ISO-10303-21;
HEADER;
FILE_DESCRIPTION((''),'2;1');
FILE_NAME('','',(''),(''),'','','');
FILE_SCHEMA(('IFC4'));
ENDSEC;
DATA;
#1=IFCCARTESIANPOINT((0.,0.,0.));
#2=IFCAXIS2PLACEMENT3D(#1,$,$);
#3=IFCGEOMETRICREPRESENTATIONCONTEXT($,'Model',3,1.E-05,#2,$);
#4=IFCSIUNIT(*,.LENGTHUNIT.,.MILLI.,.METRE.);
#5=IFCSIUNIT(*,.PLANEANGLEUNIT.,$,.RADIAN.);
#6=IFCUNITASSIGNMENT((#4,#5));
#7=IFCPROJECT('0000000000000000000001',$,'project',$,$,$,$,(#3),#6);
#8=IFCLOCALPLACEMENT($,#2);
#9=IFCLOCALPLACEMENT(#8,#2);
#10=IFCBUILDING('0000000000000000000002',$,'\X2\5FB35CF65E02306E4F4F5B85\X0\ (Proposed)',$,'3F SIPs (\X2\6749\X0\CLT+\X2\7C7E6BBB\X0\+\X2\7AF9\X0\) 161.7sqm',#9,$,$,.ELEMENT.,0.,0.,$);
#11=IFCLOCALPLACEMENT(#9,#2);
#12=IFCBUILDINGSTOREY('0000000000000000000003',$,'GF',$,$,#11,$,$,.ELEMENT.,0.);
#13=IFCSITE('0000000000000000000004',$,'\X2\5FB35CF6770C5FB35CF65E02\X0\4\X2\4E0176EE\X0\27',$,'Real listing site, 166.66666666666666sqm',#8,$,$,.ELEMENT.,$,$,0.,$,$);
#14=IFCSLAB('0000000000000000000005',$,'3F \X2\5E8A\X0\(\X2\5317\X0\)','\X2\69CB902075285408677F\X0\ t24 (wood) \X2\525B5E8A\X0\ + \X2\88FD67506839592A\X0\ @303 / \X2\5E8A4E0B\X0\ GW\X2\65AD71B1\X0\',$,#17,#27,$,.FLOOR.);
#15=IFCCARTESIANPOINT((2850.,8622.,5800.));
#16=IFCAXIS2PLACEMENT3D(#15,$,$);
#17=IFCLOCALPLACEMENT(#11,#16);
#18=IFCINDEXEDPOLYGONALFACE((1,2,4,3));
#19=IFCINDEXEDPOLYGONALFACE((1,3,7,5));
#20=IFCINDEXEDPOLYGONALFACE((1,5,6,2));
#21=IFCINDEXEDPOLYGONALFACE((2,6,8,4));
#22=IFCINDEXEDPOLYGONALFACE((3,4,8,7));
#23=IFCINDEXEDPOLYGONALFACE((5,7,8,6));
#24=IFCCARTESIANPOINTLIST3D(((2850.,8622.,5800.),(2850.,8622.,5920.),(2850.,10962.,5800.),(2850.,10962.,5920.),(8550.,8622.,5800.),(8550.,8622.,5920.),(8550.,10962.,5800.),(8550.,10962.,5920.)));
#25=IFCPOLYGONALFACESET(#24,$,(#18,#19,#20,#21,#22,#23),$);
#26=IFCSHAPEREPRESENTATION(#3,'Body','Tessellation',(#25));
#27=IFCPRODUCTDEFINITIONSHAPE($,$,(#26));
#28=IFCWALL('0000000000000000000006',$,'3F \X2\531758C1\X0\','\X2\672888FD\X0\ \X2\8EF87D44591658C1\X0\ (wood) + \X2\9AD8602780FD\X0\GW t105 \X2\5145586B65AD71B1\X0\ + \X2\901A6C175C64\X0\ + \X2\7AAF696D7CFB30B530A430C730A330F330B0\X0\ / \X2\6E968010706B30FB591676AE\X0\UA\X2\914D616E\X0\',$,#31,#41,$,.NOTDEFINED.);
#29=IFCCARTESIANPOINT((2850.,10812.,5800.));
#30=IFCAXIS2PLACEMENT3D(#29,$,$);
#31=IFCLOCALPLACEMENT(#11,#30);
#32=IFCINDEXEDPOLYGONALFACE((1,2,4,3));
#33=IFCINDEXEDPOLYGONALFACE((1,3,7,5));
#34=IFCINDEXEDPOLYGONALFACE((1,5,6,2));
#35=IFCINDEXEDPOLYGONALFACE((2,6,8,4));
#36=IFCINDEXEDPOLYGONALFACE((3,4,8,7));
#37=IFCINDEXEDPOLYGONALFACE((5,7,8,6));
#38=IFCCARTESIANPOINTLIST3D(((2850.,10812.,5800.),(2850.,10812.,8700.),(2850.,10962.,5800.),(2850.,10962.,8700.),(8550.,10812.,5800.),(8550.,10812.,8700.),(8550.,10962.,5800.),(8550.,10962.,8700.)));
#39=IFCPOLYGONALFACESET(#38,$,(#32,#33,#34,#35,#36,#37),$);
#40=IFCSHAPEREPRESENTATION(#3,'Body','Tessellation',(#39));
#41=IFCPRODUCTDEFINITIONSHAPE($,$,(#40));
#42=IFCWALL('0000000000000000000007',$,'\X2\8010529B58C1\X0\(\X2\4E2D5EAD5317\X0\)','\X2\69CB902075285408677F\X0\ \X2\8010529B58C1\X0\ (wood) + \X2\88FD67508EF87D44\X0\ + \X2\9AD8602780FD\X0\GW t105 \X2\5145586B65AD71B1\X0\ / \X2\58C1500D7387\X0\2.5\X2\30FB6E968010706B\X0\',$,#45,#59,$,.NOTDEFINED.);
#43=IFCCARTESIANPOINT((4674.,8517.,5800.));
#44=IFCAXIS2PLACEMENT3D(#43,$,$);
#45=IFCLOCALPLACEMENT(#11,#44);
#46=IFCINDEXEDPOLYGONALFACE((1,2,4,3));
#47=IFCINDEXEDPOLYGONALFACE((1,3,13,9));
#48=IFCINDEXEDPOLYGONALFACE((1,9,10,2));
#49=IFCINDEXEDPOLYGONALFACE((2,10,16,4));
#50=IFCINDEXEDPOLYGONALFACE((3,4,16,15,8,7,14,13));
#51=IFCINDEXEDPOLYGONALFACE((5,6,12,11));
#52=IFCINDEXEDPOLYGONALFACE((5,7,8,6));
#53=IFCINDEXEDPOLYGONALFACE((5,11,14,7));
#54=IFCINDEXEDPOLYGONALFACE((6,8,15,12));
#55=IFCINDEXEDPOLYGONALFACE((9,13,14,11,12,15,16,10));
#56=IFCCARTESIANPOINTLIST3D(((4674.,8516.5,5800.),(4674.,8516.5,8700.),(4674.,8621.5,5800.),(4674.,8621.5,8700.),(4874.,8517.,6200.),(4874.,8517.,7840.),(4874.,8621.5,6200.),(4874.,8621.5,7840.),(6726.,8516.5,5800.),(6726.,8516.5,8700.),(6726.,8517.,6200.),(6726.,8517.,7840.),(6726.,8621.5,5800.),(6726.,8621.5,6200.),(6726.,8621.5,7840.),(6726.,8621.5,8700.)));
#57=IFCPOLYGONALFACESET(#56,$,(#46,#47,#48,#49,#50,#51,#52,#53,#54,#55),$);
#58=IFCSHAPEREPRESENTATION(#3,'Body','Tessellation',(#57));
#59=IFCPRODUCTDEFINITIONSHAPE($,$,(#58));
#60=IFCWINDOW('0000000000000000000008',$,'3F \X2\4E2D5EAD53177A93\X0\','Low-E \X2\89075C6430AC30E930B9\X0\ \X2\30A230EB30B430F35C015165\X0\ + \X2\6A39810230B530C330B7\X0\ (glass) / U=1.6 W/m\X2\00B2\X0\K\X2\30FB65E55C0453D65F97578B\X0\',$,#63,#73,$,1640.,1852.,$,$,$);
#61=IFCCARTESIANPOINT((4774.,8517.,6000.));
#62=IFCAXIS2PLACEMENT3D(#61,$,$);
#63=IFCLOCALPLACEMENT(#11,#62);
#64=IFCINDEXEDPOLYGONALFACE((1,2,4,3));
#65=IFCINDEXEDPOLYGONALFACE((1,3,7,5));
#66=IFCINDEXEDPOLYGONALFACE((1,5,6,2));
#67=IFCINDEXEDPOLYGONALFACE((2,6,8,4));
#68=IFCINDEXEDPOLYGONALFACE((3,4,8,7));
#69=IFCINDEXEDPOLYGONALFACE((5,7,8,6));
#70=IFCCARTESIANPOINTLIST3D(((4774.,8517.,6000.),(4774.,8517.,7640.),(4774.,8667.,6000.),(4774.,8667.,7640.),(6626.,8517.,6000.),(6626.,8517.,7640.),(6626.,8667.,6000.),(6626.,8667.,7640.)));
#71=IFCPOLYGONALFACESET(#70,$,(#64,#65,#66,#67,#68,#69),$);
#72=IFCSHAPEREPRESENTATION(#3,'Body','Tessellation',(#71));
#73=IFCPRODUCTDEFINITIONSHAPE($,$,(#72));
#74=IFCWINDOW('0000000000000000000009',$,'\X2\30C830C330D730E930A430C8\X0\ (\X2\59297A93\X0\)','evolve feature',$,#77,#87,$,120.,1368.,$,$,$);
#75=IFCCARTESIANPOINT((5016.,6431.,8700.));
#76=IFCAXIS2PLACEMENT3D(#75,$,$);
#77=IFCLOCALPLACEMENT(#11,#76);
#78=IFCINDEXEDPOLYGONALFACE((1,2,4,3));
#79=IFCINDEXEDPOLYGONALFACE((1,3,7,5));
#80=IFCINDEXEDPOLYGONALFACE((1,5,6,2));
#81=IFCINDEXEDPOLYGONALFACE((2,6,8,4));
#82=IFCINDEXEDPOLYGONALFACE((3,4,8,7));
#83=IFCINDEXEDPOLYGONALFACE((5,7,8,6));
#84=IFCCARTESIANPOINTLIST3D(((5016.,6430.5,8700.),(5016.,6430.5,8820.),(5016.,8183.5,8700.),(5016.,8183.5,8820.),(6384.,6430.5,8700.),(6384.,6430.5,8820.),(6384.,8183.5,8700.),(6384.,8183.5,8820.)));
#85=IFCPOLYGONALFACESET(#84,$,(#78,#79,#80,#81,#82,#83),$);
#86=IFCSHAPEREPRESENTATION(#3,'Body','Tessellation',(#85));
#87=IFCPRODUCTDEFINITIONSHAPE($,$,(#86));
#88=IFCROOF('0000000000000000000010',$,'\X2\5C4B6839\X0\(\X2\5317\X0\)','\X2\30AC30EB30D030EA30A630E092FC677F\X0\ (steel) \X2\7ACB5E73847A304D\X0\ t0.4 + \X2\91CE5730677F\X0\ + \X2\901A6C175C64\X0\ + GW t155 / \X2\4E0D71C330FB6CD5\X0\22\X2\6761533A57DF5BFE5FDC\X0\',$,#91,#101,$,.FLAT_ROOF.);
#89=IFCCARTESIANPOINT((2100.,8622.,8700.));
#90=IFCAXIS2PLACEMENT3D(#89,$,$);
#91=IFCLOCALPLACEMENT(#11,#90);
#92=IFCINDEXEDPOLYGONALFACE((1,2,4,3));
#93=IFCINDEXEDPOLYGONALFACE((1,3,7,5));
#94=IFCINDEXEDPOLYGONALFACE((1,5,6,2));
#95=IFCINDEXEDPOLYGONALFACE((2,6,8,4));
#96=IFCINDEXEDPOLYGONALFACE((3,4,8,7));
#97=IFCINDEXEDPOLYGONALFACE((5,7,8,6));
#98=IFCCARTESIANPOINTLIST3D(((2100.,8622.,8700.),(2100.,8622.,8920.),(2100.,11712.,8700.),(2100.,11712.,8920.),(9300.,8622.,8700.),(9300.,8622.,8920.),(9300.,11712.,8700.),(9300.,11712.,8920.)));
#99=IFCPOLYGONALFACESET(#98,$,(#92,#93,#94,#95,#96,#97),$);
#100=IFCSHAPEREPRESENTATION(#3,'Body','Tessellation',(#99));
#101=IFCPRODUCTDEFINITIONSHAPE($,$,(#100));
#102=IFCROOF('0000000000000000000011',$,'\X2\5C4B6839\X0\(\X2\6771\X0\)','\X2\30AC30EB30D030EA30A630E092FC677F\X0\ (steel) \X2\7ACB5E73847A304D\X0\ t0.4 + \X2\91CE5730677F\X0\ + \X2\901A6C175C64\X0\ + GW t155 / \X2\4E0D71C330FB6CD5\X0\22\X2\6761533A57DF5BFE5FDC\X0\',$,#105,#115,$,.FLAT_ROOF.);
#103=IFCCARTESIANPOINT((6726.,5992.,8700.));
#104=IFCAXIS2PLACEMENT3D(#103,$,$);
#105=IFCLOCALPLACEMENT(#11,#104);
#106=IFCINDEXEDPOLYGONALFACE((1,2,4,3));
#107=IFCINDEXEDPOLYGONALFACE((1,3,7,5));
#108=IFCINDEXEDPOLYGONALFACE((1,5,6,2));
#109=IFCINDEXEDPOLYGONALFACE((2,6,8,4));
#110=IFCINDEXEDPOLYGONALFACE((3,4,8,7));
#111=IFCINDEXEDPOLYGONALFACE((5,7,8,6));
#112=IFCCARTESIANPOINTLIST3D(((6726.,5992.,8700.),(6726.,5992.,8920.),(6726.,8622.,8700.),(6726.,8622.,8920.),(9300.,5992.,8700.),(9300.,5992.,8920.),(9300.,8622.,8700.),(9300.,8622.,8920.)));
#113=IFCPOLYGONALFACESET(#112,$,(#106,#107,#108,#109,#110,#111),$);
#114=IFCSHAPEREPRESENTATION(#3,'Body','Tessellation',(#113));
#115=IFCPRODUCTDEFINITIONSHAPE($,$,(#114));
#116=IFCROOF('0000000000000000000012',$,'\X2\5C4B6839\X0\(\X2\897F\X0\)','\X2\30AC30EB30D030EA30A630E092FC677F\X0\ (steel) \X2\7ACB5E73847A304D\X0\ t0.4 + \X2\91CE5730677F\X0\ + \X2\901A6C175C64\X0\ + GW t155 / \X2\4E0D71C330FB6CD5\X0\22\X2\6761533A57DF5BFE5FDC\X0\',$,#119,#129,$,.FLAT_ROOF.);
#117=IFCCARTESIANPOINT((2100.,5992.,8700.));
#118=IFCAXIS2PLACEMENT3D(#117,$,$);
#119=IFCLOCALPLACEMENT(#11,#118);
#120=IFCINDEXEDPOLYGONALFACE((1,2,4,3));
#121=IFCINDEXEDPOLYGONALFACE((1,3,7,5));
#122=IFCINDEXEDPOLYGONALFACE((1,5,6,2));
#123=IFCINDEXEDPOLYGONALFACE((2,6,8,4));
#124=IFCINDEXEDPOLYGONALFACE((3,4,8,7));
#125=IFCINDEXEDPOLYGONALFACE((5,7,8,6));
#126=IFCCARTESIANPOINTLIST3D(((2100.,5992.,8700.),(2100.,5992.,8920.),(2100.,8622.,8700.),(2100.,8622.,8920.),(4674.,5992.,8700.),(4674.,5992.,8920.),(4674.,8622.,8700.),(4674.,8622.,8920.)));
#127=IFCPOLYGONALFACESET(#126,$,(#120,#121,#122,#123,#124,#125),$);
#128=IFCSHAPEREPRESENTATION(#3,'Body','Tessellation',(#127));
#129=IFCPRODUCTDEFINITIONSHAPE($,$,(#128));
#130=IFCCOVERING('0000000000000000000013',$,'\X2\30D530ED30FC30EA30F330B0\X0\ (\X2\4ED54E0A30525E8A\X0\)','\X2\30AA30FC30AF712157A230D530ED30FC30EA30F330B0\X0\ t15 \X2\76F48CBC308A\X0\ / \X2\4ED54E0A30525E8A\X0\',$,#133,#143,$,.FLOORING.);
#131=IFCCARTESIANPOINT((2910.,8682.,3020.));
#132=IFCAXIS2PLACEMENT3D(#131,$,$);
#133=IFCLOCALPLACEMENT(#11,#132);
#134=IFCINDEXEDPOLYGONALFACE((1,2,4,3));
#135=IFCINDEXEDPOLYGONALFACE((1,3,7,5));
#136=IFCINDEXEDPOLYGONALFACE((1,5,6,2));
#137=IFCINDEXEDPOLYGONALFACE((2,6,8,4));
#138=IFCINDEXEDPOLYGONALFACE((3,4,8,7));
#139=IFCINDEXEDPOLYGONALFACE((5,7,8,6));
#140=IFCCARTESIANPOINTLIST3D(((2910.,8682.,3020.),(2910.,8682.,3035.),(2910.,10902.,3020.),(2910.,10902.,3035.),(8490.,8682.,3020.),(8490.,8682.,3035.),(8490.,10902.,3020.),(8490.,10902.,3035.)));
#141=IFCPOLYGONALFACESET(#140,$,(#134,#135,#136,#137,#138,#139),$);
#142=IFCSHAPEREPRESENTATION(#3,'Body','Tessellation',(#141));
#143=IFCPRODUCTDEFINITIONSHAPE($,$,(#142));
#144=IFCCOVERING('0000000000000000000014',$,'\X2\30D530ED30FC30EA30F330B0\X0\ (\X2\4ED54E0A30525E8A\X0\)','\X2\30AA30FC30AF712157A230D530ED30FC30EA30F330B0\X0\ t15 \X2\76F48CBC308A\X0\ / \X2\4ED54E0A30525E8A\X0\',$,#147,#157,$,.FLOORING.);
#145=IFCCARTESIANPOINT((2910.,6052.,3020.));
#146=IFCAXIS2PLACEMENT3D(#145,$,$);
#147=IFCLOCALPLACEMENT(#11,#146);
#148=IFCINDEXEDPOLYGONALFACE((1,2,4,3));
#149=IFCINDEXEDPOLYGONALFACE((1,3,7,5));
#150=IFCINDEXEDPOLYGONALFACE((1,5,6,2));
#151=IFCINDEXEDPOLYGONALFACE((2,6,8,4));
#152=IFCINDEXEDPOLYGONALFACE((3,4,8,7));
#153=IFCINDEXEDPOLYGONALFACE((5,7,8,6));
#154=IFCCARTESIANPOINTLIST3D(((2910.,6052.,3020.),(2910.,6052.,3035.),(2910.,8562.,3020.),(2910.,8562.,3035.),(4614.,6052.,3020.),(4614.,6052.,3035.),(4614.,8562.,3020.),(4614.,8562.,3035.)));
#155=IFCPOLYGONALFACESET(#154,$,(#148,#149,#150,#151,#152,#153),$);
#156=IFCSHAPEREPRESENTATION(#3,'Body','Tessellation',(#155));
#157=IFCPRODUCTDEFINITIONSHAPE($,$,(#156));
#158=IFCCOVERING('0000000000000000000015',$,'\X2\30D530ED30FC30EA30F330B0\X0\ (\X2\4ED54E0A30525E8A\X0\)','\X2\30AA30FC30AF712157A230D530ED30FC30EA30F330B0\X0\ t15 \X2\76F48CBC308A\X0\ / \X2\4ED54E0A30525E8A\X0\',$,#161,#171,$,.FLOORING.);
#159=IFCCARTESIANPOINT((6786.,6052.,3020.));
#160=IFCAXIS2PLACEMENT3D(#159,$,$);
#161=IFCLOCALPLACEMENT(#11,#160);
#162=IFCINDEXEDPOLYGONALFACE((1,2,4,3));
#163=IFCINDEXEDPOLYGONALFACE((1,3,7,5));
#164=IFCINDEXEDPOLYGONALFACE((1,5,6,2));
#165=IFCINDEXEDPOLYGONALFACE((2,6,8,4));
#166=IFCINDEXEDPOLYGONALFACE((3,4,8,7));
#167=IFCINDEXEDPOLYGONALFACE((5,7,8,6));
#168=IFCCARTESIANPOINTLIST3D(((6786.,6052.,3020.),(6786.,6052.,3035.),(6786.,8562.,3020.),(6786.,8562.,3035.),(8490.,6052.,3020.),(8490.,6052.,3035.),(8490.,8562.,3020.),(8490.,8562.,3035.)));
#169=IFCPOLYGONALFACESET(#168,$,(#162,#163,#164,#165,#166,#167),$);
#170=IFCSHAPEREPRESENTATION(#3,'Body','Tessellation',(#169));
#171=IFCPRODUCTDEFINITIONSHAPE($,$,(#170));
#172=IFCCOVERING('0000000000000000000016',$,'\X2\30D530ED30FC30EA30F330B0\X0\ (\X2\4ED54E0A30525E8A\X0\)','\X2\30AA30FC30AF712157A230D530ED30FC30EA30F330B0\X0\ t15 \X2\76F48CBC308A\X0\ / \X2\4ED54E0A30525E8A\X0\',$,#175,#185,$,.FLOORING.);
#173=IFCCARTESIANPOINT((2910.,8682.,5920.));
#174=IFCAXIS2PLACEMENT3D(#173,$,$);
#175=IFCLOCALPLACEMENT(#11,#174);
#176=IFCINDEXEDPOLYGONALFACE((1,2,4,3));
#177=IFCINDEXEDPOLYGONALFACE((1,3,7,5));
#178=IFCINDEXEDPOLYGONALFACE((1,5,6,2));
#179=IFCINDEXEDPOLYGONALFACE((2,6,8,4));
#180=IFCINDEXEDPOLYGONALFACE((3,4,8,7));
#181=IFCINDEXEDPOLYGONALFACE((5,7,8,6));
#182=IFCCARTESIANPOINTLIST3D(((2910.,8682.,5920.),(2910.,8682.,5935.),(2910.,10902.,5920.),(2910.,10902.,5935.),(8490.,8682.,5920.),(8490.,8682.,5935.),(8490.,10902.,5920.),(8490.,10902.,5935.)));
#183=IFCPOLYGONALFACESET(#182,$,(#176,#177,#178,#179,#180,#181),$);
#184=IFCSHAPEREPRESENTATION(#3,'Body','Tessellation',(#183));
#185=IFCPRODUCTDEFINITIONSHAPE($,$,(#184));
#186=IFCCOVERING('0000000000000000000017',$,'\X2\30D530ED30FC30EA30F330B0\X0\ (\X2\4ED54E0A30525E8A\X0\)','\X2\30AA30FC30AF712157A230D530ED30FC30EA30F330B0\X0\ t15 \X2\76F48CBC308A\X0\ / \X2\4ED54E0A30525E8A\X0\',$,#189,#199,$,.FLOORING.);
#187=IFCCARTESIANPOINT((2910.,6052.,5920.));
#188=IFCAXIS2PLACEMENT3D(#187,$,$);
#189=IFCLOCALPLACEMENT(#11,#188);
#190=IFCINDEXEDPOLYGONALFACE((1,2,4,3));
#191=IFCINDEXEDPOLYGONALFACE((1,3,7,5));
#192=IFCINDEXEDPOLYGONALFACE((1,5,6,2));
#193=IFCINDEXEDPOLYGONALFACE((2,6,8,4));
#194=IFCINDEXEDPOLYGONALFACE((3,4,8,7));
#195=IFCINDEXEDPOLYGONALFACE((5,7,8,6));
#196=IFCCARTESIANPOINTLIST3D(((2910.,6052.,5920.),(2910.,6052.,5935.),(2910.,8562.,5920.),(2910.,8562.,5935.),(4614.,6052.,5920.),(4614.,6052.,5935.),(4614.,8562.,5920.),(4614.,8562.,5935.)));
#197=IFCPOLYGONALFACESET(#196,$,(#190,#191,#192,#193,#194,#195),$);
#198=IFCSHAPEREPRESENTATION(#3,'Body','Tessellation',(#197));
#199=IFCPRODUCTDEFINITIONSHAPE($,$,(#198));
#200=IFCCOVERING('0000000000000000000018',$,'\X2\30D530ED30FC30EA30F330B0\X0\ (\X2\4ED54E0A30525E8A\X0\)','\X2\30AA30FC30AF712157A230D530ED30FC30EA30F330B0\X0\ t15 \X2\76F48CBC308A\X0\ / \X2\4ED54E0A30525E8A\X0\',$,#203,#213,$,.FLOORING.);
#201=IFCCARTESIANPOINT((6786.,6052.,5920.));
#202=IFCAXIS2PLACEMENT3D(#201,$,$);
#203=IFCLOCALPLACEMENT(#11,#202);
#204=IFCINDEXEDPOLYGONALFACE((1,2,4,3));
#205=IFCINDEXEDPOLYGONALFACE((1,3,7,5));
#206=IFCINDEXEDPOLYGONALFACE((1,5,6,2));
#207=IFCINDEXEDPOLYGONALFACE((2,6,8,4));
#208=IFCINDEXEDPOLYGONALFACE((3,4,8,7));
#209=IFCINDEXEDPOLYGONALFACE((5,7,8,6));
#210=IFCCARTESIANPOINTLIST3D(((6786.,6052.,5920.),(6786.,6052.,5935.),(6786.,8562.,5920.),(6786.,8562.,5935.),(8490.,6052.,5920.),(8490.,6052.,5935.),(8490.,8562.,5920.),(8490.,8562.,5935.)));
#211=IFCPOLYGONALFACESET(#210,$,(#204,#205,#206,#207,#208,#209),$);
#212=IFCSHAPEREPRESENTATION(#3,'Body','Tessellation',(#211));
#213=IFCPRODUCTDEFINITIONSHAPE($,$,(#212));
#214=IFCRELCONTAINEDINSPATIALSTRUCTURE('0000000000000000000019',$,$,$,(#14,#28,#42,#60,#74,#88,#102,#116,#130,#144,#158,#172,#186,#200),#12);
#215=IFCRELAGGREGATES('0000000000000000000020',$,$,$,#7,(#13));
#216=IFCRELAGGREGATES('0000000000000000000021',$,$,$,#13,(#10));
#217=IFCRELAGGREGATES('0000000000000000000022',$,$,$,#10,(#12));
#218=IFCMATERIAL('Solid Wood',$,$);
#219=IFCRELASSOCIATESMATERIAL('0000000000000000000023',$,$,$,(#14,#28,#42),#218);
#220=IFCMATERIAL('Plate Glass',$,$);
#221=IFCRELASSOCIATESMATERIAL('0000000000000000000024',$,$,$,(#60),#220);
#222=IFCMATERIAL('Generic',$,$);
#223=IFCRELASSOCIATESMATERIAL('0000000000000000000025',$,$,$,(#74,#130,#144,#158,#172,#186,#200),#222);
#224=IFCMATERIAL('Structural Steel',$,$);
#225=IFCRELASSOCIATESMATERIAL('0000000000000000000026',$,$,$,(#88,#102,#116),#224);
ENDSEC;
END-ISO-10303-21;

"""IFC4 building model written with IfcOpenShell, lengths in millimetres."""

from ifc_helpers import new_model, si_unit, frame, frame_2d, origin, place, context, project, spatial, rectangle, extrude, material, element, fill, save


model = new_model("IFC4")

# Units and contexts
model_context = context("Model", 3, precision=1e-05, world=origin())
ifc_project = project(units=[si_unit("LENGTHUNIT", "METRE", prefix="MILLI"), si_unit("PLANEANGLEUNIT", "RADIAN")], contexts=[model_context])

# Site, building, storey
site_placement = place(None, origin())
site = spatial("IfcSite", under=ifc_project, at=site_placement, Name="徳島県徳島市4丁目27", ObjectType="Real listing site, 166.66666666666666sqm", CompositionType="ELEMENT", RefElevation=0.0)
building_placement = place(site_placement, origin())
building = spatial("IfcBuilding", under=site, at=building_placement, Name="徳島市の住宅 (Proposed)", ObjectType="3F SIPs (杉CLT+籾殻+竹) 161.7sqm", CompositionType="ELEMENT", ElevationOfRefHeight=0.0, ElevationOfTerrain=0.0)
storey_placement = place(building_placement, origin())
storey = spatial("IfcBuildingStorey", under=building, at=storey_placement, Name="GF", CompositionType="ELEMENT", Elevation=0.0)

# Slab
ifc_material_1 = material(Name="Solid Wood")
slab_placement = place(storey_placement, frame((2850.0, 8622.0, 5800.0)))
element("IfcSlab", 1, at=slab_placement, inside=storey, material=ifc_material_1, Name="3F 床(北)", Description="構造用合板 t24 (wood) 剛床 + 製材根太 @303 / 床下 GW断熱", PredefinedType="FLOOR", context=model_context, shape_type="SweptSolid", body=[
    extrude(rectangle(XDim=5700.0, YDim=2340.0, at=frame_2d((2850.0, 1170.0))), frame((2850.0, 8622.0, 5800.0)), (0.0, 0.0, 1.0), 120.0),
])

# Wall
wall_1_placement = place(storey_placement, frame((2850.0, 10812.0, 5800.0)))
element("IfcWall", 2, at=wall_1_placement, inside=storey, material=ifc_material_1, Name="3F 北壁", Description="木製 軸組外壁 (wood) + 高性能GW t105 充填断熱 + 通気層 + 窯業系サイディング / 準耐火・外皮UA配慮", PredefinedType="NOTDEFINED", context=model_context, shape_type="SweptSolid", body=[
    extrude(rectangle(XDim=5700.0, YDim=150.0, at=frame_2d((2850.0, 75.0))), frame((2850.0, 10812.0, 5800.0)), (0.0, 0.0, 1.0), 2900.0),
])

# Wall, opening, window
wall_2_placement = place(storey_placement, frame((4674.0, 8517.0, 5800.0)))
wall_2 = element("IfcWall", 3, at=wall_2_placement, inside=storey, material=ifc_material_1, Name="耐力壁(中庭北)", Description="構造用合板 耐力壁 (wood) + 製材軸組 + 高性能GW t105 充填断熱 / 壁倍率2.5・準耐火", PredefinedType="NOTDEFINED", context=model_context, shape_type="SweptSolid", body=[
    extrude(rectangle(XDim=2052.0, YDim=105.0, at=frame_2d((1026.0, 52.0))), frame((4674.0, 8517.0, 5800.0)), (0.0, 0.0, 1.0), 2900.0),
])
opening_placement = place(storey_placement, frame((4774.0, 8517.0, 6000.0)))
opening = element("IfcOpeningElement", 4, at=opening_placement, cuts=wall_2, PredefinedType="NOTDEFINED", context=model_context, shape_type="SweptSolid", body=[
    extrude(rectangle(XDim=1852.0, YDim=150.0, at=frame_2d((926.0, 75.0))), frame((4774.0, 8517.0, 6000.0)), (0.0, 0.0, 1.0), 1640.0),
])
ifc_material_2 = material(Name="Plate Glass")
window_1_placement = place(storey_placement, frame((4774.0, 8517.0, 6000.0)))
window_1 = element("IfcWindow", 5, at=window_1_placement, inside=storey, material=ifc_material_2, Name="3F 中庭北窓", Description="Low-E 複層ガラス アルゴン封入 + 樹脂サッシ (glass) / U=1.6 W/m²K・日射取得型", OverallHeight=1640.0, OverallWidth=1852.0, context=model_context, shape_type="SweptSolid", body=[
    extrude(rectangle(XDim=1852.0, YDim=150.0, at=frame_2d((926.0, 75.0))), frame((4774.0, 8517.0, 6000.0)), (0.0, 0.0, 1.0), 1640.0),
])
fill(opening, window_1)

# Window
ifc_material_3 = material(Name="Generic")
window_2_placement = place(storey_placement, frame((5016.0, 6431.0, 8700.0)))
element("IfcWindow", 6, at=window_2_placement, inside=storey, material=ifc_material_3, Name="トップライト (天窓)", Description="evolve feature", OverallHeight=120.0, OverallWidth=1368.0, context=model_context, shape_type="SweptSolid", body=[
    extrude(rectangle(XDim=1368.0, YDim=1753.0, at=frame_2d((684.0, 876.0))), frame((5016.0, 6431.0, 8700.0)), (0.0, 0.0, 1.0), 120.0),
])

# Roofs
ifc_material_4 = material(Name="Structural Steel")
roof_1_placement = place(storey_placement, frame((2100.0, 8622.0, 8700.0)))
element("IfcRoof", 7, at=roof_1_placement, inside=storey, material=ifc_material_4, Name="屋根(北)", Description="ガルバリウム鋼板 (steel) 立平葺き t0.4 + 野地板 + 通気層 + GW t155 / 不燃・法22条区域対応", PredefinedType="FLAT_ROOF", context=model_context, shape_type="SweptSolid", body=[
    extrude(rectangle(XDim=7200.0, YDim=3090.0, at=frame_2d((3600.0, 1545.0))), frame((2100.0, 8622.0, 8700.0)), (0.0, 0.0, 1.0), 220.0),
])
roof_2_placement = place(storey_placement, frame((6726.0, 5992.0, 8700.0)))
element("IfcRoof", 8, at=roof_2_placement, inside=storey, material=ifc_material_4, Name="屋根(東)", Description="ガルバリウム鋼板 (steel) 立平葺き t0.4 + 野地板 + 通気層 + GW t155 / 不燃・法22条区域対応", PredefinedType="FLAT_ROOF", context=model_context, shape_type="SweptSolid", body=[
    extrude(rectangle(XDim=2574.0, YDim=2630.0, at=frame_2d((1287.0, 1315.0))), frame((6726.0, 5992.0, 8700.0)), (0.0, 0.0, 1.0), 220.0),
])
roof_3_placement = place(storey_placement, frame((2100.0, 5992.0, 8700.0)))
element("IfcRoof", 9, at=roof_3_placement, inside=storey, material=ifc_material_4, Name="屋根(西)", Description="ガルバリウム鋼板 (steel) 立平葺き t0.4 + 野地板 + 通気層 + GW t155 / 不燃・法22条区域対応", PredefinedType="FLAT_ROOF", context=model_context, shape_type="SweptSolid", body=[
    extrude(rectangle(XDim=2574.0, YDim=2630.0, at=frame_2d((1287.0, 1315.0))), frame((2100.0, 5992.0, 8700.0)), (0.0, 0.0, 1.0), 220.0),
])

# Coverings
covering_1_placement = place(storey_placement, frame((2910.0, 8682.0, 3020.0)))
element("IfcCovering", 10, at=covering_1_placement, inside=storey, material=ifc_material_3, Name="フローリング (仕上げ床)", Description="オーク無垢フローリング t15 直貼り / 仕上げ床", PredefinedType="FLOORING", context=model_context, shape_type="SweptSolid", body=[
    extrude(rectangle(XDim=5580.0, YDim=2220.0, at=frame_2d((2790.0, 1110.0))), frame((2910.0, 8682.0, 3020.0)), (0.0, 0.0, 1.0), 15.0),
])
covering_2_placement = place(storey_placement, frame((2910.0, 6052.0, 3020.0)))
element("IfcCovering", 11, at=covering_2_placement, inside=storey, material=ifc_material_3, Name="フローリング (仕上げ床)", Description="オーク無垢フローリング t15 直貼り / 仕上げ床", PredefinedType="FLOORING", context=model_context, shape_type="SweptSolid", body=[
    extrude(rectangle(XDim=1704.0, YDim=2510.0, at=frame_2d((852.0, 1255.0))), frame((2910.0, 6052.0, 3020.0)), (0.0, 0.0, 1.0), 15.0),
])
covering_3_placement = place(storey_placement, frame((6786.0, 6052.0, 3020.0)))
element("IfcCovering", 12, at=covering_3_placement, inside=storey, material=ifc_material_3, Name="フローリング (仕上げ床)", Description="オーク無垢フローリング t15 直貼り / 仕上げ床", PredefinedType="FLOORING", context=model_context, shape_type="SweptSolid", body=[
    extrude(rectangle(XDim=1704.0, YDim=2510.0, at=frame_2d((852.0, 1255.0))), frame((6786.0, 6052.0, 3020.0)), (0.0, 0.0, 1.0), 15.0),
])
covering_4_placement = place(storey_placement, frame((2910.0, 8682.0, 5920.0)))
element("IfcCovering", 13, at=covering_4_placement, inside=storey, material=ifc_material_3, Name="フローリング (仕上げ床)", Description="オーク無垢フローリング t15 直貼り / 仕上げ床", PredefinedType="FLOORING", context=model_context, shape_type="SweptSolid", body=[
    extrude(rectangle(XDim=5580.0, YDim=2220.0, at=frame_2d((2790.0, 1110.0))), frame((2910.0, 8682.0, 5920.0)), (0.0, 0.0, 1.0), 15.0),
])
covering_5_placement = place(storey_placement, frame((2910.0, 6052.0, 5920.0)))
element("IfcCovering", 14, at=covering_5_placement, inside=storey, material=ifc_material_3, Name="フローリング (仕上げ床)", Description="オーク無垢フローリング t15 直貼り / 仕上げ床", PredefinedType="FLOORING", context=model_context, shape_type="SweptSolid", body=[
    extrude(rectangle(XDim=1704.0, YDim=2510.0, at=frame_2d((852.0, 1255.0))), frame((2910.0, 6052.0, 5920.0)), (0.0, 0.0, 1.0), 15.0),
])
covering_6_placement = place(storey_placement, frame((6786.0, 6052.0, 5920.0)))
element("IfcCovering", 15, at=covering_6_placement, inside=storey, material=ifc_material_3, Name="フローリング (仕上げ床)", Description="オーク無垢フローリング t15 直貼り / 仕上げ床", PredefinedType="FLOORING", context=model_context, shape_type="SweptSolid", body=[
    extrude(rectangle(XDim=1704.0, YDim=2510.0, at=frame_2d((852.0, 1255.0))), frame((6786.0, 6052.0, 5920.0)), (0.0, 0.0, 1.0), 15.0),
])

save(model, "model.ifc")
